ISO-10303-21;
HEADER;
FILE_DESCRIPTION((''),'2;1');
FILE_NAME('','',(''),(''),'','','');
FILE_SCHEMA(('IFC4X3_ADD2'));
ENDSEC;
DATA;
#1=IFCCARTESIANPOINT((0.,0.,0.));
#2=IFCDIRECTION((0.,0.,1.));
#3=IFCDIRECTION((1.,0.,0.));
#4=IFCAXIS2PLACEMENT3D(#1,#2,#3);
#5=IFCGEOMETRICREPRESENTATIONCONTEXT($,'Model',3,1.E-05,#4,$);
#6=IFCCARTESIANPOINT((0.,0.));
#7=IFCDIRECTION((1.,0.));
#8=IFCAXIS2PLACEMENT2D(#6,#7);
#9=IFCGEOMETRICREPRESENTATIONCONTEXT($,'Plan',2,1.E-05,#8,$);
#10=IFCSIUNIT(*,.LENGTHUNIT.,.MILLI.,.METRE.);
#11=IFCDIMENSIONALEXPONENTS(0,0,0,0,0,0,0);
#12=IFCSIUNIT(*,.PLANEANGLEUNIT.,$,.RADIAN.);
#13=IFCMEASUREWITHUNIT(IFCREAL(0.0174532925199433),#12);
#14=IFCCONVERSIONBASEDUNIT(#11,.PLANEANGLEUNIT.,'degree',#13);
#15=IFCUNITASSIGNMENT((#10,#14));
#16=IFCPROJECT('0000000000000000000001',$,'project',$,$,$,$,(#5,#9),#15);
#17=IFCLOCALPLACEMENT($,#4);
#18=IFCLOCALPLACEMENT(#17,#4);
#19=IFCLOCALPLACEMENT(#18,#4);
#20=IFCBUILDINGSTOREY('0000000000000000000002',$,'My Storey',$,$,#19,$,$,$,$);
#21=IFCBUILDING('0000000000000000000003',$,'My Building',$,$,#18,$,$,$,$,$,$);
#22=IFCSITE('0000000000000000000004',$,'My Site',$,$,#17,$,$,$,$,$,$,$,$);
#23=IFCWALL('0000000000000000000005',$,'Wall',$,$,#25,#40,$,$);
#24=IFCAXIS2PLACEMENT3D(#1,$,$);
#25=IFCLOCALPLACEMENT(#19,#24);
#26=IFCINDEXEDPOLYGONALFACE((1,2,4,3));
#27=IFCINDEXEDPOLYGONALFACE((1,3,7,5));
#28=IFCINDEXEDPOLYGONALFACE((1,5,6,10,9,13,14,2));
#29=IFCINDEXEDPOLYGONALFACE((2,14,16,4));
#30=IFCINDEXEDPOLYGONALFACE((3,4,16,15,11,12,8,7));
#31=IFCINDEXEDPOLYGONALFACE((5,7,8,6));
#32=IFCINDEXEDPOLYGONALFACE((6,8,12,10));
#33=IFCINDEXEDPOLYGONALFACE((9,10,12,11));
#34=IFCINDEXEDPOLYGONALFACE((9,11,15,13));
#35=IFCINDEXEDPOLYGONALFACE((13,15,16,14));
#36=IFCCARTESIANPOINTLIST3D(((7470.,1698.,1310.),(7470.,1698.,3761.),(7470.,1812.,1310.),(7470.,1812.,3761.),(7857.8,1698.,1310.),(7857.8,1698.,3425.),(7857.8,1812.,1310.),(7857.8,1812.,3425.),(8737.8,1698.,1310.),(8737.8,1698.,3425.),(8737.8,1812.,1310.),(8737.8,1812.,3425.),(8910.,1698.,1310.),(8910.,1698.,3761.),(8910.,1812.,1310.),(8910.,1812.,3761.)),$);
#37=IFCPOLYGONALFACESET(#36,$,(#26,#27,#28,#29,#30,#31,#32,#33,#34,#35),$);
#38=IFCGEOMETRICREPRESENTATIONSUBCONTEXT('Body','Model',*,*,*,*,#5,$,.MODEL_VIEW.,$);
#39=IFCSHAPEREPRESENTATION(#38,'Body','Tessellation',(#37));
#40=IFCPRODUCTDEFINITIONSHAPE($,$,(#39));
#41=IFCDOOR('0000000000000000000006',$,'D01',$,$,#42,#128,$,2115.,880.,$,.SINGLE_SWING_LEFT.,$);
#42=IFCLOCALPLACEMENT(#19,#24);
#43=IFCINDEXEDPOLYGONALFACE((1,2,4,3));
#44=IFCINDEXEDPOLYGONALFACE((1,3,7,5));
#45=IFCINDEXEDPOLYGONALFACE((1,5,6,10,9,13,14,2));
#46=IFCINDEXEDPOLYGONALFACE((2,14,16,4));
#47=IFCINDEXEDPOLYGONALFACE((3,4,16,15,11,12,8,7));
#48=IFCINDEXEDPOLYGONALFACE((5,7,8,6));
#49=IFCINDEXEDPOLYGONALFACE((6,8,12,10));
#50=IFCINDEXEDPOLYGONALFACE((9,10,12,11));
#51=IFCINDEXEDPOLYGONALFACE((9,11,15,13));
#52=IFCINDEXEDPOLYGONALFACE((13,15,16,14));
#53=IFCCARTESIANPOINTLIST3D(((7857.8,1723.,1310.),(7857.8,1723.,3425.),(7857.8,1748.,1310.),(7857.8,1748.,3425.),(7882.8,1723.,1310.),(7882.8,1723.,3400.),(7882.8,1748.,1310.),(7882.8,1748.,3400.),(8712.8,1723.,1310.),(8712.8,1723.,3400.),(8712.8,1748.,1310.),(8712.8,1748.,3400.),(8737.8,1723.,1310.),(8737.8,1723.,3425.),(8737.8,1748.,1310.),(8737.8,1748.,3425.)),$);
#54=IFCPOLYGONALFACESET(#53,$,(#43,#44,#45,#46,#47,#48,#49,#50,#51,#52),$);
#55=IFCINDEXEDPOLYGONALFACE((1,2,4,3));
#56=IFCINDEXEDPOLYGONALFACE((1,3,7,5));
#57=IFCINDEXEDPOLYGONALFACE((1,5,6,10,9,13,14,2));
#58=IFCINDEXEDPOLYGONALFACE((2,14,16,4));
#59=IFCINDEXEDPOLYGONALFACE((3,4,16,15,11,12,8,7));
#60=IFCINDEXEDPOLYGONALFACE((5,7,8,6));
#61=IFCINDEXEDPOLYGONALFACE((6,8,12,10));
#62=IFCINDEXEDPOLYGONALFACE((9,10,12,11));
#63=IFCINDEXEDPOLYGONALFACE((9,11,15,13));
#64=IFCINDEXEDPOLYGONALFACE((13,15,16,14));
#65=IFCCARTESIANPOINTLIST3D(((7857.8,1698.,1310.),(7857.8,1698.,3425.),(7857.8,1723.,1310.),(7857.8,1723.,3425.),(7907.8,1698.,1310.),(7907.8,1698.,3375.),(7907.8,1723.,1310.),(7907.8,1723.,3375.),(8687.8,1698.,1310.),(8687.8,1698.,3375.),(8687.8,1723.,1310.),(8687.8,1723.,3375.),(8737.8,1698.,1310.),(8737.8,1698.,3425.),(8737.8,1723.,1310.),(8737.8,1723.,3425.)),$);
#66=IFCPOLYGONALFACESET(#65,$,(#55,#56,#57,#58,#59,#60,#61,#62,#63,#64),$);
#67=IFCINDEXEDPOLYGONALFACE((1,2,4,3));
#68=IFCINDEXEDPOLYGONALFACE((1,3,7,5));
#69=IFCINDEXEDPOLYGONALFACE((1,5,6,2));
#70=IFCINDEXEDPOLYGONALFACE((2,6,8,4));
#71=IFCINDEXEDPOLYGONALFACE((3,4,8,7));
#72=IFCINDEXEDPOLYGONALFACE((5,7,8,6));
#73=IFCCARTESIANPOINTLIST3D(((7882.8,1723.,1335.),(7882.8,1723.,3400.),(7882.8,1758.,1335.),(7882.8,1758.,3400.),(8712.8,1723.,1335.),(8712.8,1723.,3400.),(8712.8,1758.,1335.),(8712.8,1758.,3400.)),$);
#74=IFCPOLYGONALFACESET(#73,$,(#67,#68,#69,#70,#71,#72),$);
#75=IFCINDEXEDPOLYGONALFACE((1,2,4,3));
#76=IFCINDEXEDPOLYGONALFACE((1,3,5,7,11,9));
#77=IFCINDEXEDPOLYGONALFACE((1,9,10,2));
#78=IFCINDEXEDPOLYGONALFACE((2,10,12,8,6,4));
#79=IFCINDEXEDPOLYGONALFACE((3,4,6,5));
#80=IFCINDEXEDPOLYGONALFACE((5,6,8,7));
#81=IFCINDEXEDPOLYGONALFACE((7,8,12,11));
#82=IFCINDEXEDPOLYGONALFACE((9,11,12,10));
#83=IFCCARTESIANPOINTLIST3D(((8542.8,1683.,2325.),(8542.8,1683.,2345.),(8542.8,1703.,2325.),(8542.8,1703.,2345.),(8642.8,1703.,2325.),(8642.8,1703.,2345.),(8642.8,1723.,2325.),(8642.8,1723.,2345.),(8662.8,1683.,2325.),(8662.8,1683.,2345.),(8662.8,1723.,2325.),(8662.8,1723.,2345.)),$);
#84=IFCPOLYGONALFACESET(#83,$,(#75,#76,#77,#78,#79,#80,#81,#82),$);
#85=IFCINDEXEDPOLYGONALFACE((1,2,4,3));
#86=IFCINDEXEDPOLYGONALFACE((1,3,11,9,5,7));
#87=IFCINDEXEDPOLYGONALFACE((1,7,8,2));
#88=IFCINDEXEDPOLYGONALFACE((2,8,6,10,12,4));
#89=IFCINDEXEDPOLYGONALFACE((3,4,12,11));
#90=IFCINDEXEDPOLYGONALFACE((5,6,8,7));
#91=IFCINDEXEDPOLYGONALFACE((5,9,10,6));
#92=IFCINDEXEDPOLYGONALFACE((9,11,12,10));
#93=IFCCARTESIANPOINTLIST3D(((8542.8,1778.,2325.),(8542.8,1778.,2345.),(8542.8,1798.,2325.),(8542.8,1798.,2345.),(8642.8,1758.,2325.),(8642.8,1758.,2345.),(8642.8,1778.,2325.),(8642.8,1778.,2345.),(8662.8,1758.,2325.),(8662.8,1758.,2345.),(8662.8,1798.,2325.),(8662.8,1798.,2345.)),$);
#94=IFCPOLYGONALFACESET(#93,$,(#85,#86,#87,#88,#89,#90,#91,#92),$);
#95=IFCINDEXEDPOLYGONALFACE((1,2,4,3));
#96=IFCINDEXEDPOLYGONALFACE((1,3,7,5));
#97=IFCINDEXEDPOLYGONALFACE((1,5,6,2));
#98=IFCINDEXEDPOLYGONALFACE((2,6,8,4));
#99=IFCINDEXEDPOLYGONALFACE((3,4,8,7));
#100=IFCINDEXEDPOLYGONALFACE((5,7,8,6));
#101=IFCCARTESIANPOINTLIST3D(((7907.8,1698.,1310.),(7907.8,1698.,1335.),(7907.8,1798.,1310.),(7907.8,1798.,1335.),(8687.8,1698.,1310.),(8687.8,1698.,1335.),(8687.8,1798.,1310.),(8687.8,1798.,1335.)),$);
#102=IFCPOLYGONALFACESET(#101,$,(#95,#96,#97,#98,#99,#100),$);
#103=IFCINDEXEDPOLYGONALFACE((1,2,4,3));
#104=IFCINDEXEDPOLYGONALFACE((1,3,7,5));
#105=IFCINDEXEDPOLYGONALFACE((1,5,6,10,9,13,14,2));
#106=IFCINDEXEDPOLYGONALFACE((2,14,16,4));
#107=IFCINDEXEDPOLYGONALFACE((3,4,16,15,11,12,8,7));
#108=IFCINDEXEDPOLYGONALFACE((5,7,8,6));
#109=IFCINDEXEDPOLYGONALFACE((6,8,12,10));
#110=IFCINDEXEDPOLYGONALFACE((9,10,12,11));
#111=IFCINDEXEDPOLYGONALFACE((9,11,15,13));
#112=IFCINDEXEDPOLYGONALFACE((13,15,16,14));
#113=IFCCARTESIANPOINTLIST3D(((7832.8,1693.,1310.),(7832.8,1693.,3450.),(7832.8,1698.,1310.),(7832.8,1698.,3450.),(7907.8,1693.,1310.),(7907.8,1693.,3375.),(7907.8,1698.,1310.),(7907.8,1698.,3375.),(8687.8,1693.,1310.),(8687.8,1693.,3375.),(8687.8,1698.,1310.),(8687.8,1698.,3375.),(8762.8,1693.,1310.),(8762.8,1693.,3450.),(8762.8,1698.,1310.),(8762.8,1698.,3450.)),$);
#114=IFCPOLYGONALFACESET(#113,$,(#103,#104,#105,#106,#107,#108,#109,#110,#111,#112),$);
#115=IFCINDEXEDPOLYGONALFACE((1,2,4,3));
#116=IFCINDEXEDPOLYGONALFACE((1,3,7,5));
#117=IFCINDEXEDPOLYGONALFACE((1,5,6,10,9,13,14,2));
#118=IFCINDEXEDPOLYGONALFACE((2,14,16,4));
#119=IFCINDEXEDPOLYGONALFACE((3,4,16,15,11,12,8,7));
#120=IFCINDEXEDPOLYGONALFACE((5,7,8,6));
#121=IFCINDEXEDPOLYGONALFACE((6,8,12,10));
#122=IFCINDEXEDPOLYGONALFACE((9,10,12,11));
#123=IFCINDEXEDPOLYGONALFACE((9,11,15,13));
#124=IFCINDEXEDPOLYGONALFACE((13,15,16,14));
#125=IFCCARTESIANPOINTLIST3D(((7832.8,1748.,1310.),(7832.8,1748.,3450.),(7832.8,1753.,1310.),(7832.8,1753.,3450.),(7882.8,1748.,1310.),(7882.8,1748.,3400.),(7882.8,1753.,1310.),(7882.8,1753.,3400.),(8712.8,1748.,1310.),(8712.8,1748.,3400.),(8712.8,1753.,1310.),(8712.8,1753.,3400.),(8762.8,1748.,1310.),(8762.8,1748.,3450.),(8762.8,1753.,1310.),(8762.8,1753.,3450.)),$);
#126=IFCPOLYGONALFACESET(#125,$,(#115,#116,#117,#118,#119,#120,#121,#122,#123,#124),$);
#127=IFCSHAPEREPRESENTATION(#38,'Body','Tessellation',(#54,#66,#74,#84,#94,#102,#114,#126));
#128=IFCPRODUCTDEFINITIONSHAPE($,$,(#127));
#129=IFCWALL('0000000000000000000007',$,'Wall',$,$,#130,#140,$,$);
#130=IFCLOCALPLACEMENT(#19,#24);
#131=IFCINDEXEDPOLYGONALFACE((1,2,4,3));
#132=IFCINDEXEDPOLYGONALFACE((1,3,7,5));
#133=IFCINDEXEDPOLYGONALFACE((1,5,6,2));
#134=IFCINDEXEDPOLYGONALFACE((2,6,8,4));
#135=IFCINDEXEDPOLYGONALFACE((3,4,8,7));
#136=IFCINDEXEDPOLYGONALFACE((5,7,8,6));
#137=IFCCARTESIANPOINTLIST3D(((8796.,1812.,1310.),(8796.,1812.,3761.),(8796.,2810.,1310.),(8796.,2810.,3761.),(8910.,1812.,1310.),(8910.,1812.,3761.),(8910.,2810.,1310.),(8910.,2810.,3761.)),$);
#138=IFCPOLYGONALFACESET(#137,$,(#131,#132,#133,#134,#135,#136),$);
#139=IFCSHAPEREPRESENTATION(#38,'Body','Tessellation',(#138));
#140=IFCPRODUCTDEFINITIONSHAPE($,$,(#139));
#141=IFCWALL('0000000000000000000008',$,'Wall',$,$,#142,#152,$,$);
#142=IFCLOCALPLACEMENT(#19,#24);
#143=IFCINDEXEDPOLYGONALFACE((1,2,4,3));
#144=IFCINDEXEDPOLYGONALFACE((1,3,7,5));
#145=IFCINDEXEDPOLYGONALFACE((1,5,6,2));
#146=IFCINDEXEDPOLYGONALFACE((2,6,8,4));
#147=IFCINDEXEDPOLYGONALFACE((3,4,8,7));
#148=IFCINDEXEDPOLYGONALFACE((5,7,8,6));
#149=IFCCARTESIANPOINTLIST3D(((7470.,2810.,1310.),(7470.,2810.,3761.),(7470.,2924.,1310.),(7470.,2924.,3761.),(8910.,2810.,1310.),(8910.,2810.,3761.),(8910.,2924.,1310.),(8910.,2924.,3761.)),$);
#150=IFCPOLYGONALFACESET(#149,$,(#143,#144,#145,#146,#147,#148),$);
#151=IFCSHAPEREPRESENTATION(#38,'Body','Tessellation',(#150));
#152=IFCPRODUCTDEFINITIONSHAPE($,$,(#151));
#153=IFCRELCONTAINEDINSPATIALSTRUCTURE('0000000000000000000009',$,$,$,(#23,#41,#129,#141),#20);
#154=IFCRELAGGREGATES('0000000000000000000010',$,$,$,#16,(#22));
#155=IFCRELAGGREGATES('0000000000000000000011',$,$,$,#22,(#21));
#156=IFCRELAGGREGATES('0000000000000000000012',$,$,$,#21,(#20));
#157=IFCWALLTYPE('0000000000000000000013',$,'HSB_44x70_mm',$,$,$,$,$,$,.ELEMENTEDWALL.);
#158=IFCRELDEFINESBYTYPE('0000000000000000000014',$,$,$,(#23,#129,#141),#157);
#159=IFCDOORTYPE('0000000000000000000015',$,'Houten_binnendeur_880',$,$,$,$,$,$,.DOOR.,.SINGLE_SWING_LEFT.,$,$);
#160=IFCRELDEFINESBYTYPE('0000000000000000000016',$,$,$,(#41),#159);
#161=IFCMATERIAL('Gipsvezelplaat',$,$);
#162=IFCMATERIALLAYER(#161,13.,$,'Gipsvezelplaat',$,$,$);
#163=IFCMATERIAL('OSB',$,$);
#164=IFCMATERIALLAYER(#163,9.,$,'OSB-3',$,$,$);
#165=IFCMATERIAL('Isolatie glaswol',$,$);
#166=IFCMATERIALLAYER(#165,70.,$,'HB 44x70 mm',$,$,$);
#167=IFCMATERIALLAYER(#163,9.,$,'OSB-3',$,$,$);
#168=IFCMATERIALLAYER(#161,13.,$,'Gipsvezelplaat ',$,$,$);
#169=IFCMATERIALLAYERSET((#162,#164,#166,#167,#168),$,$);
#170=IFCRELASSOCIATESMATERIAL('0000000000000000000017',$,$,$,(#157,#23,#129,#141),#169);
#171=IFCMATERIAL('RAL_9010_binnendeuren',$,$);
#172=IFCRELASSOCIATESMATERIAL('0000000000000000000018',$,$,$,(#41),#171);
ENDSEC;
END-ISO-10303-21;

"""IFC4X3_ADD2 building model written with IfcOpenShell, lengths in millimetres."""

from ifc_helpers import new_model, entity, si_unit, converted_unit, frame, origin_with_axes, origin_2d_with_axis, place, context, subcontext, project, spatial, line, indexed_curve, outline, extrude, shape, source, transform, mapped, material, layer, layer_set, layer_usage, type_object, type_shapes, element, fill, save


model = new_model("IFC4X3_ADD2")

# Units and contexts
model_context = context("Model", 3, precision=1e-05, world=origin_with_axes())
plan_context = context("Plan", 2, precision=1e-05, world=origin_2d_with_axis())
body_context_1 = subcontext(model_context, "Body", "Model", "MODEL_VIEW")
body_context_2 = subcontext(plan_context, "Body", "Plan", "PLAN_VIEW")
ifc_project = project(units=[si_unit("LENGTHUNIT", "METRE", prefix="MILLI"), converted_unit("PLANEANGLEUNIT", "degree", entity("IfcReal", 0.0174532925199433), si_unit("PLANEANGLEUNIT", "RADIAN"), dimensions=[0, 0, 0, 0, 0, 0, 0])], contexts=[model_context, plan_context])

# Site, building, storey
site_placement = place(None, origin_with_axes())
site = spatial("IfcSite", under=ifc_project, at=site_placement, Name="My Site")
building_placement = place(site_placement, origin_with_axes())
building = spatial("IfcBuilding", under=site, at=building_placement, Name="My Building")
storey_placement = place(building_placement, origin_with_axes())
storey = spatial("IfcBuildingStorey", under=building, at=storey_placement, Name="My Storey")

# Shared definitions
ifc_material_1 = material(Name="Isolatie glaswol")
ifc_material_2 = material(Name="Gipsvezelplaat")

# Shared definitions
ifc_material_3 = material(Name="OSB")

# Shared definitions
ifc_layer_1 = layer(ifc_material_2, 13.0, Name="Gipsvezelplaat")
ifc_layer_2 = layer(ifc_material_3, 9.0, Name="OSB-3")
ifc_layer_3 = layer(ifc_material_1, 70.0, Name="HB 44x70 mm")
ifc_layer_4 = layer(ifc_material_3, 9.0, Name="OSB-3")
ifc_layer_5 = layer(ifc_material_2, 13.0, Name="Gipsvezelplaat ")
ifc_layer_set_1 = layer_set([ifc_layer_1, ifc_layer_2, ifc_layer_3, ifc_layer_4, ifc_layer_5])
wall_type_1 = type_object("IfcWallType", Name="HSB_44x70_mm", PredefinedType="ELEMENTEDWALL", material=ifc_layer_set_1)

# Wall, opening, door
ifc_layer_usage_1 = layer_usage(ifc_layer_set_1, "AXIS2", "POSITIVE", 0.0)
wall_1_placement = place(storey_placement, frame((7470.0, 1698.0, 1310.0), z_axis=(0.0, 0.0, 1.0), x_axis=(1.0, 0.0, 0.0)))
wall_1 = element("IfcWall", 1, at=wall_1_placement, inside=storey, type_object=wall_type_1, material=ifc_layer_usage_1, Name="Wall", context=body_context_1, shape_type="SweptSolid", body=[
    extrude(outline(indexed_curve([(0.0, 0.0), (0.0, 114.0), (1440.0, 114.0), (1440.0, 0.0), (0.0, 0.0)], self_intersect=False)), origin_with_axes(), (0.0, 0.0, 1.0), 2451.0),
])
shared_shape_1 = source(origin_with_axes(), body_context_1, "Body", "SweptSolid", [
    extrude(outline(indexed_curve([(0.0, 0.0), (880.0, 0.0), (880.0, 2115.0), (0.0, 2115.0)], segments=[line(1, 2, 3, 4, 1)])), frame((0.0, -600.0, 0.0), z_axis=(0.0, -1.0, 0.0), x_axis=(1.0, 0.0, 0.0)), (0.0, 0.0, -1.0), 1200.0),
])
opening_1_placement = place(wall_1_placement, frame((387.8, 0.0, 0.0), z_axis=(0.0, 0.0, 1.0), x_axis=(1.0, 0.0, 0.0)))
opening_1 = element("IfcOpeningElement", 2, at=opening_1_placement, cuts=wall_1, PredefinedType="OPENING", context=body_context_1, shape_type="MappedRepresentation", body=[
    mapped(shared_shape_1, transform((0.0, 0.0, 0.0), x_axis=(1.0, 0.0, 0.0), y_axis=(0.0, 1.0, 0.0), z_axis=(0.0, 0.0, 1.0), scale=1.0)),
])
ifc_material_4 = material(Name="RAL_9010_binnendeuren")
door_type_1 = type_object("IfcDoorType", Name="Houten_binnendeur_880", OperationType="SINGLE_SWING_LEFT", PredefinedType="DOOR")
shared_shape_2 = source(origin_with_axes(), body_context_1, "Body", "SweptSolid", [
    extrude(outline(indexed_curve([(0.0, 0.0), (0.0, 2115.0), (880.0, 2115.0), (880.0, 0.0), (855.0, 0.0), (855.0, 2090.0), (25.0, 2090.0), (25.0, 0.0)], segments=[line(1, 2, 3, 4, 5, 6, 7, 8, 1)])), frame((0.0, 25.0, 0.0), z_axis=(0.0, -1.0, 0.0), x_axis=(1.0, 0.0, 0.0)), (0.0, 0.0, -1.0), 25.0),
    extrude(outline(indexed_curve([(0.0, 0.0), (0.0, 2115.0), (880.0, 2115.0), (880.0, 0.0), (830.0, 0.0), (830.0, 2065.0), (50.0, 2065.0), (50.0, 0.0)], segments=[line(1, 2, 3, 4, 5, 6, 7, 8, 1)])), frame((0.0, 0.0, 0.0), z_axis=(0.0, -1.0, 0.0), x_axis=(1.0, 0.0, 0.0)), (0.0, 0.0, -1.0), 25.0),
    extrude(outline(indexed_curve([(0.0, 0.0), (830.0, 0.0), (830.0, 35.0), (0.0, 35.0)], segments=[line(1, 2, 3, 4, 1)])), frame((25.0, 25.0, 25.0), z_axis=(0.0, 0.0, 1.0), x_axis=(1.0, 0.0, 0.0)), (0.0, 0.0, 1.0), 2065.0),
    extrude(outline(indexed_curve([(0.0, 0.0), (0.0, -40.0), (-120.0, -40.0), (-120.0, -20.0), (-20.0, -20.0), (-20.0, 0.0)], segments=[line(1, 2, 3, 4, 5, 6, 1)])), frame((805.0, 25.0, 1015.0), z_axis=(0.0, 0.0, 1.0), x_axis=(1.0, 0.0, 0.0)), (0.0, 0.0, 1.0), 20.0),
    extrude(outline(indexed_curve([(0.0, 0.0), (0.0, 40.0), (-120.0, 40.0), (-120.0, 20.0), (-20.0, 20.0), (-20.0, 0.0)], segments=[line(1, 2, 3, 4, 5, 6, 1)])), frame((805.0, 60.0, 1015.0), z_axis=(0.0, 0.0, 1.0), x_axis=(1.0, 0.0, 0.0)), (0.0, 0.0, 1.0), 20.0),
    extrude(outline(indexed_curve([(0.0, 0.0), (780.0, 0.0), (780.0, 100.0), (0.0, 100.0)], segments=[line(1, 2, 3, 4, 1)])), frame((50.0, 0.0, 0.0), z_axis=(0.0, 0.0, 1.0), x_axis=(1.0, 0.0, 0.0)), (0.0, 0.0, 1.0), 25.0),
    extrude(outline(indexed_curve([(0.0, 0.0), (0.0, 2140.0), (930.0, 2140.0), (930.0, 0.0), (855.0, 0.0), (855.0, 2065.0), (75.0, 2065.0), (75.0, 0.0)], segments=[line(1, 2, 3, 4, 5, 6, 7, 8, 1)])), frame((-25.0, -5.0, 0.0), z_axis=(0.0, -1.0, 0.0), x_axis=(1.0, 0.0, 0.0)), (0.0, 0.0, -1.0), 5.0),
    extrude(outline(indexed_curve([(0.0, 0.0), (0.0, 2140.0), (930.0, 2140.0), (930.0, 0.0), (880.0, 0.0), (880.0, 2090.0), (50.0, 2090.0), (50.0, 0.0)], segments=[line(1, 2, 3, 4, 5, 6, 7, 8, 1)])), frame((-25.0, 50.0, 0.0), z_axis=(0.0, -1.0, 0.0), x_axis=(1.0, 0.0, 0.0)), (0.0, 0.0, -1.0), 5.0),
])
shared_shape_3 = source(origin_with_axes(), body_context_2, "Body", "Curve2D", [
    entity("IfcIndexedPolyCurve", entity("IfcCartesianPointList2D", [[0.0, 0.0], [0.0, 50.0], [25.0, 50.0], [25.0, 25.0], [50.0, 25.0], [50.0, 0.0]]), [entity("IfcLineIndex", [1, 2, 3, 4, 5, 6, 1])]),
    entity("IfcIndexedPolyCurve", entity("IfcCartesianPointList2D", [[880.0, 0.0], [880.0, 50.0], [855.0, 50.0], [855.0, 25.0], [830.0, 25.0], [830.0, 0.0]]), [entity("IfcLineIndex", [1, 2, 3, 4, 5, 6, 1])]),
    entity("IfcTrimmedCurve", entity("IfcEllipse", entity("IfcAxis2Placement2D", entity("IfcCartesianPoint", [60.0, 50.0]), entity("IfcDirection", [1.0, 0.0])), 795.0, 830.0), [entity("IfcCartesianPoint", [855.0, 50.0])], [entity("IfcCartesianPoint", [60.0, 880.0])], True, "CARTESIAN"),
    entity("IfcIndexedPolyCurve", entity("IfcCartesianPointList2D", [[25.0, 50.0], [60.0, 50.0], [60.0, 880.0], [25.0, 880.0]]), [entity("IfcLineIndex", [1, 2, 3, 4, 1])]),
])
type_shapes(door_type_1, [shared_shape_2, shared_shape_3])
door_1_placement = place(opening_1_placement, origin_with_axes())
door_1 = element("IfcDoor", 3, at=door_1_placement, inside=storey, type_object=door_type_1, material=ifc_material_4, Name="D01", OperationType="SINGLE_SWING_LEFT", OverallHeight=2115.0, OverallWidth=880.0, shapes=[
    shape(body_context_1, "Body", "MappedRepresentation", [mapped(shared_shape_2, transform((0.0, 0.0, 0.0), x_axis=(1.0, 0.0, 0.0), y_axis=(0.0, 1.0, 0.0), z_axis=(0.0, 0.0, 1.0), scale=1.0))]),
    shape(body_context_2, "Body", "MappedRepresentation", [mapped(shared_shape_3, transform((0.0, 0.0, 0.0), x_axis=(1.0, 0.0, 0.0), y_axis=(0.0, 1.0, 0.0), z_axis=(0.0, 0.0, 1.0), scale=1.0))]),
])
fill(opening_1, door_1)

# Walls
ifc_layer_usage_2 = layer_usage(ifc_layer_set_1, "AXIS2", "POSITIVE", 0.0)
wall_2_placement = place(storey_placement, frame((8910.0, 1812.0, 1310.0), z_axis=(0.0, 0.0, 1.0), x_axis=(0.0, 1.0, 0.0)))
element("IfcWall", 4, at=wall_2_placement, inside=storey, type_object=wall_type_1, material=ifc_layer_usage_2, Name="Wall", context=body_context_1, shape_type="SweptSolid", body=[
    extrude(outline(indexed_curve([(0.0, 0.0), (0.0, 114.0), (998.0, 114.0), (998.0, 0.0), (0.0, 0.0)], self_intersect=False)), origin_with_axes(), (0.0, 0.0, 1.0), 2451.0),
])
ifc_layer_usage_3 = layer_usage(ifc_layer_set_1, "AXIS2", "POSITIVE", 0.0)
wall_3_placement = place(storey_placement, frame((7470.0, 2810.0, 1310.0), z_axis=(0.0, 0.0, 1.0), x_axis=(1.0, 0.0, 0.0)))
element("IfcWall", 5, at=wall_3_placement, inside=storey, type_object=wall_type_1, material=ifc_layer_usage_3, Name="Wall", context=body_context_1, shape_type="SweptSolid", body=[
    extrude(outline(indexed_curve([(0.0, 0.0), (0.0, 114.0), (1440.0, 114.0), (1440.0, 0.0), (0.0, 0.0)], self_intersect=False)), origin_with_axes(), (0.0, 0.0, 1.0), 2451.0),
])

save(model, "model.ifc")
